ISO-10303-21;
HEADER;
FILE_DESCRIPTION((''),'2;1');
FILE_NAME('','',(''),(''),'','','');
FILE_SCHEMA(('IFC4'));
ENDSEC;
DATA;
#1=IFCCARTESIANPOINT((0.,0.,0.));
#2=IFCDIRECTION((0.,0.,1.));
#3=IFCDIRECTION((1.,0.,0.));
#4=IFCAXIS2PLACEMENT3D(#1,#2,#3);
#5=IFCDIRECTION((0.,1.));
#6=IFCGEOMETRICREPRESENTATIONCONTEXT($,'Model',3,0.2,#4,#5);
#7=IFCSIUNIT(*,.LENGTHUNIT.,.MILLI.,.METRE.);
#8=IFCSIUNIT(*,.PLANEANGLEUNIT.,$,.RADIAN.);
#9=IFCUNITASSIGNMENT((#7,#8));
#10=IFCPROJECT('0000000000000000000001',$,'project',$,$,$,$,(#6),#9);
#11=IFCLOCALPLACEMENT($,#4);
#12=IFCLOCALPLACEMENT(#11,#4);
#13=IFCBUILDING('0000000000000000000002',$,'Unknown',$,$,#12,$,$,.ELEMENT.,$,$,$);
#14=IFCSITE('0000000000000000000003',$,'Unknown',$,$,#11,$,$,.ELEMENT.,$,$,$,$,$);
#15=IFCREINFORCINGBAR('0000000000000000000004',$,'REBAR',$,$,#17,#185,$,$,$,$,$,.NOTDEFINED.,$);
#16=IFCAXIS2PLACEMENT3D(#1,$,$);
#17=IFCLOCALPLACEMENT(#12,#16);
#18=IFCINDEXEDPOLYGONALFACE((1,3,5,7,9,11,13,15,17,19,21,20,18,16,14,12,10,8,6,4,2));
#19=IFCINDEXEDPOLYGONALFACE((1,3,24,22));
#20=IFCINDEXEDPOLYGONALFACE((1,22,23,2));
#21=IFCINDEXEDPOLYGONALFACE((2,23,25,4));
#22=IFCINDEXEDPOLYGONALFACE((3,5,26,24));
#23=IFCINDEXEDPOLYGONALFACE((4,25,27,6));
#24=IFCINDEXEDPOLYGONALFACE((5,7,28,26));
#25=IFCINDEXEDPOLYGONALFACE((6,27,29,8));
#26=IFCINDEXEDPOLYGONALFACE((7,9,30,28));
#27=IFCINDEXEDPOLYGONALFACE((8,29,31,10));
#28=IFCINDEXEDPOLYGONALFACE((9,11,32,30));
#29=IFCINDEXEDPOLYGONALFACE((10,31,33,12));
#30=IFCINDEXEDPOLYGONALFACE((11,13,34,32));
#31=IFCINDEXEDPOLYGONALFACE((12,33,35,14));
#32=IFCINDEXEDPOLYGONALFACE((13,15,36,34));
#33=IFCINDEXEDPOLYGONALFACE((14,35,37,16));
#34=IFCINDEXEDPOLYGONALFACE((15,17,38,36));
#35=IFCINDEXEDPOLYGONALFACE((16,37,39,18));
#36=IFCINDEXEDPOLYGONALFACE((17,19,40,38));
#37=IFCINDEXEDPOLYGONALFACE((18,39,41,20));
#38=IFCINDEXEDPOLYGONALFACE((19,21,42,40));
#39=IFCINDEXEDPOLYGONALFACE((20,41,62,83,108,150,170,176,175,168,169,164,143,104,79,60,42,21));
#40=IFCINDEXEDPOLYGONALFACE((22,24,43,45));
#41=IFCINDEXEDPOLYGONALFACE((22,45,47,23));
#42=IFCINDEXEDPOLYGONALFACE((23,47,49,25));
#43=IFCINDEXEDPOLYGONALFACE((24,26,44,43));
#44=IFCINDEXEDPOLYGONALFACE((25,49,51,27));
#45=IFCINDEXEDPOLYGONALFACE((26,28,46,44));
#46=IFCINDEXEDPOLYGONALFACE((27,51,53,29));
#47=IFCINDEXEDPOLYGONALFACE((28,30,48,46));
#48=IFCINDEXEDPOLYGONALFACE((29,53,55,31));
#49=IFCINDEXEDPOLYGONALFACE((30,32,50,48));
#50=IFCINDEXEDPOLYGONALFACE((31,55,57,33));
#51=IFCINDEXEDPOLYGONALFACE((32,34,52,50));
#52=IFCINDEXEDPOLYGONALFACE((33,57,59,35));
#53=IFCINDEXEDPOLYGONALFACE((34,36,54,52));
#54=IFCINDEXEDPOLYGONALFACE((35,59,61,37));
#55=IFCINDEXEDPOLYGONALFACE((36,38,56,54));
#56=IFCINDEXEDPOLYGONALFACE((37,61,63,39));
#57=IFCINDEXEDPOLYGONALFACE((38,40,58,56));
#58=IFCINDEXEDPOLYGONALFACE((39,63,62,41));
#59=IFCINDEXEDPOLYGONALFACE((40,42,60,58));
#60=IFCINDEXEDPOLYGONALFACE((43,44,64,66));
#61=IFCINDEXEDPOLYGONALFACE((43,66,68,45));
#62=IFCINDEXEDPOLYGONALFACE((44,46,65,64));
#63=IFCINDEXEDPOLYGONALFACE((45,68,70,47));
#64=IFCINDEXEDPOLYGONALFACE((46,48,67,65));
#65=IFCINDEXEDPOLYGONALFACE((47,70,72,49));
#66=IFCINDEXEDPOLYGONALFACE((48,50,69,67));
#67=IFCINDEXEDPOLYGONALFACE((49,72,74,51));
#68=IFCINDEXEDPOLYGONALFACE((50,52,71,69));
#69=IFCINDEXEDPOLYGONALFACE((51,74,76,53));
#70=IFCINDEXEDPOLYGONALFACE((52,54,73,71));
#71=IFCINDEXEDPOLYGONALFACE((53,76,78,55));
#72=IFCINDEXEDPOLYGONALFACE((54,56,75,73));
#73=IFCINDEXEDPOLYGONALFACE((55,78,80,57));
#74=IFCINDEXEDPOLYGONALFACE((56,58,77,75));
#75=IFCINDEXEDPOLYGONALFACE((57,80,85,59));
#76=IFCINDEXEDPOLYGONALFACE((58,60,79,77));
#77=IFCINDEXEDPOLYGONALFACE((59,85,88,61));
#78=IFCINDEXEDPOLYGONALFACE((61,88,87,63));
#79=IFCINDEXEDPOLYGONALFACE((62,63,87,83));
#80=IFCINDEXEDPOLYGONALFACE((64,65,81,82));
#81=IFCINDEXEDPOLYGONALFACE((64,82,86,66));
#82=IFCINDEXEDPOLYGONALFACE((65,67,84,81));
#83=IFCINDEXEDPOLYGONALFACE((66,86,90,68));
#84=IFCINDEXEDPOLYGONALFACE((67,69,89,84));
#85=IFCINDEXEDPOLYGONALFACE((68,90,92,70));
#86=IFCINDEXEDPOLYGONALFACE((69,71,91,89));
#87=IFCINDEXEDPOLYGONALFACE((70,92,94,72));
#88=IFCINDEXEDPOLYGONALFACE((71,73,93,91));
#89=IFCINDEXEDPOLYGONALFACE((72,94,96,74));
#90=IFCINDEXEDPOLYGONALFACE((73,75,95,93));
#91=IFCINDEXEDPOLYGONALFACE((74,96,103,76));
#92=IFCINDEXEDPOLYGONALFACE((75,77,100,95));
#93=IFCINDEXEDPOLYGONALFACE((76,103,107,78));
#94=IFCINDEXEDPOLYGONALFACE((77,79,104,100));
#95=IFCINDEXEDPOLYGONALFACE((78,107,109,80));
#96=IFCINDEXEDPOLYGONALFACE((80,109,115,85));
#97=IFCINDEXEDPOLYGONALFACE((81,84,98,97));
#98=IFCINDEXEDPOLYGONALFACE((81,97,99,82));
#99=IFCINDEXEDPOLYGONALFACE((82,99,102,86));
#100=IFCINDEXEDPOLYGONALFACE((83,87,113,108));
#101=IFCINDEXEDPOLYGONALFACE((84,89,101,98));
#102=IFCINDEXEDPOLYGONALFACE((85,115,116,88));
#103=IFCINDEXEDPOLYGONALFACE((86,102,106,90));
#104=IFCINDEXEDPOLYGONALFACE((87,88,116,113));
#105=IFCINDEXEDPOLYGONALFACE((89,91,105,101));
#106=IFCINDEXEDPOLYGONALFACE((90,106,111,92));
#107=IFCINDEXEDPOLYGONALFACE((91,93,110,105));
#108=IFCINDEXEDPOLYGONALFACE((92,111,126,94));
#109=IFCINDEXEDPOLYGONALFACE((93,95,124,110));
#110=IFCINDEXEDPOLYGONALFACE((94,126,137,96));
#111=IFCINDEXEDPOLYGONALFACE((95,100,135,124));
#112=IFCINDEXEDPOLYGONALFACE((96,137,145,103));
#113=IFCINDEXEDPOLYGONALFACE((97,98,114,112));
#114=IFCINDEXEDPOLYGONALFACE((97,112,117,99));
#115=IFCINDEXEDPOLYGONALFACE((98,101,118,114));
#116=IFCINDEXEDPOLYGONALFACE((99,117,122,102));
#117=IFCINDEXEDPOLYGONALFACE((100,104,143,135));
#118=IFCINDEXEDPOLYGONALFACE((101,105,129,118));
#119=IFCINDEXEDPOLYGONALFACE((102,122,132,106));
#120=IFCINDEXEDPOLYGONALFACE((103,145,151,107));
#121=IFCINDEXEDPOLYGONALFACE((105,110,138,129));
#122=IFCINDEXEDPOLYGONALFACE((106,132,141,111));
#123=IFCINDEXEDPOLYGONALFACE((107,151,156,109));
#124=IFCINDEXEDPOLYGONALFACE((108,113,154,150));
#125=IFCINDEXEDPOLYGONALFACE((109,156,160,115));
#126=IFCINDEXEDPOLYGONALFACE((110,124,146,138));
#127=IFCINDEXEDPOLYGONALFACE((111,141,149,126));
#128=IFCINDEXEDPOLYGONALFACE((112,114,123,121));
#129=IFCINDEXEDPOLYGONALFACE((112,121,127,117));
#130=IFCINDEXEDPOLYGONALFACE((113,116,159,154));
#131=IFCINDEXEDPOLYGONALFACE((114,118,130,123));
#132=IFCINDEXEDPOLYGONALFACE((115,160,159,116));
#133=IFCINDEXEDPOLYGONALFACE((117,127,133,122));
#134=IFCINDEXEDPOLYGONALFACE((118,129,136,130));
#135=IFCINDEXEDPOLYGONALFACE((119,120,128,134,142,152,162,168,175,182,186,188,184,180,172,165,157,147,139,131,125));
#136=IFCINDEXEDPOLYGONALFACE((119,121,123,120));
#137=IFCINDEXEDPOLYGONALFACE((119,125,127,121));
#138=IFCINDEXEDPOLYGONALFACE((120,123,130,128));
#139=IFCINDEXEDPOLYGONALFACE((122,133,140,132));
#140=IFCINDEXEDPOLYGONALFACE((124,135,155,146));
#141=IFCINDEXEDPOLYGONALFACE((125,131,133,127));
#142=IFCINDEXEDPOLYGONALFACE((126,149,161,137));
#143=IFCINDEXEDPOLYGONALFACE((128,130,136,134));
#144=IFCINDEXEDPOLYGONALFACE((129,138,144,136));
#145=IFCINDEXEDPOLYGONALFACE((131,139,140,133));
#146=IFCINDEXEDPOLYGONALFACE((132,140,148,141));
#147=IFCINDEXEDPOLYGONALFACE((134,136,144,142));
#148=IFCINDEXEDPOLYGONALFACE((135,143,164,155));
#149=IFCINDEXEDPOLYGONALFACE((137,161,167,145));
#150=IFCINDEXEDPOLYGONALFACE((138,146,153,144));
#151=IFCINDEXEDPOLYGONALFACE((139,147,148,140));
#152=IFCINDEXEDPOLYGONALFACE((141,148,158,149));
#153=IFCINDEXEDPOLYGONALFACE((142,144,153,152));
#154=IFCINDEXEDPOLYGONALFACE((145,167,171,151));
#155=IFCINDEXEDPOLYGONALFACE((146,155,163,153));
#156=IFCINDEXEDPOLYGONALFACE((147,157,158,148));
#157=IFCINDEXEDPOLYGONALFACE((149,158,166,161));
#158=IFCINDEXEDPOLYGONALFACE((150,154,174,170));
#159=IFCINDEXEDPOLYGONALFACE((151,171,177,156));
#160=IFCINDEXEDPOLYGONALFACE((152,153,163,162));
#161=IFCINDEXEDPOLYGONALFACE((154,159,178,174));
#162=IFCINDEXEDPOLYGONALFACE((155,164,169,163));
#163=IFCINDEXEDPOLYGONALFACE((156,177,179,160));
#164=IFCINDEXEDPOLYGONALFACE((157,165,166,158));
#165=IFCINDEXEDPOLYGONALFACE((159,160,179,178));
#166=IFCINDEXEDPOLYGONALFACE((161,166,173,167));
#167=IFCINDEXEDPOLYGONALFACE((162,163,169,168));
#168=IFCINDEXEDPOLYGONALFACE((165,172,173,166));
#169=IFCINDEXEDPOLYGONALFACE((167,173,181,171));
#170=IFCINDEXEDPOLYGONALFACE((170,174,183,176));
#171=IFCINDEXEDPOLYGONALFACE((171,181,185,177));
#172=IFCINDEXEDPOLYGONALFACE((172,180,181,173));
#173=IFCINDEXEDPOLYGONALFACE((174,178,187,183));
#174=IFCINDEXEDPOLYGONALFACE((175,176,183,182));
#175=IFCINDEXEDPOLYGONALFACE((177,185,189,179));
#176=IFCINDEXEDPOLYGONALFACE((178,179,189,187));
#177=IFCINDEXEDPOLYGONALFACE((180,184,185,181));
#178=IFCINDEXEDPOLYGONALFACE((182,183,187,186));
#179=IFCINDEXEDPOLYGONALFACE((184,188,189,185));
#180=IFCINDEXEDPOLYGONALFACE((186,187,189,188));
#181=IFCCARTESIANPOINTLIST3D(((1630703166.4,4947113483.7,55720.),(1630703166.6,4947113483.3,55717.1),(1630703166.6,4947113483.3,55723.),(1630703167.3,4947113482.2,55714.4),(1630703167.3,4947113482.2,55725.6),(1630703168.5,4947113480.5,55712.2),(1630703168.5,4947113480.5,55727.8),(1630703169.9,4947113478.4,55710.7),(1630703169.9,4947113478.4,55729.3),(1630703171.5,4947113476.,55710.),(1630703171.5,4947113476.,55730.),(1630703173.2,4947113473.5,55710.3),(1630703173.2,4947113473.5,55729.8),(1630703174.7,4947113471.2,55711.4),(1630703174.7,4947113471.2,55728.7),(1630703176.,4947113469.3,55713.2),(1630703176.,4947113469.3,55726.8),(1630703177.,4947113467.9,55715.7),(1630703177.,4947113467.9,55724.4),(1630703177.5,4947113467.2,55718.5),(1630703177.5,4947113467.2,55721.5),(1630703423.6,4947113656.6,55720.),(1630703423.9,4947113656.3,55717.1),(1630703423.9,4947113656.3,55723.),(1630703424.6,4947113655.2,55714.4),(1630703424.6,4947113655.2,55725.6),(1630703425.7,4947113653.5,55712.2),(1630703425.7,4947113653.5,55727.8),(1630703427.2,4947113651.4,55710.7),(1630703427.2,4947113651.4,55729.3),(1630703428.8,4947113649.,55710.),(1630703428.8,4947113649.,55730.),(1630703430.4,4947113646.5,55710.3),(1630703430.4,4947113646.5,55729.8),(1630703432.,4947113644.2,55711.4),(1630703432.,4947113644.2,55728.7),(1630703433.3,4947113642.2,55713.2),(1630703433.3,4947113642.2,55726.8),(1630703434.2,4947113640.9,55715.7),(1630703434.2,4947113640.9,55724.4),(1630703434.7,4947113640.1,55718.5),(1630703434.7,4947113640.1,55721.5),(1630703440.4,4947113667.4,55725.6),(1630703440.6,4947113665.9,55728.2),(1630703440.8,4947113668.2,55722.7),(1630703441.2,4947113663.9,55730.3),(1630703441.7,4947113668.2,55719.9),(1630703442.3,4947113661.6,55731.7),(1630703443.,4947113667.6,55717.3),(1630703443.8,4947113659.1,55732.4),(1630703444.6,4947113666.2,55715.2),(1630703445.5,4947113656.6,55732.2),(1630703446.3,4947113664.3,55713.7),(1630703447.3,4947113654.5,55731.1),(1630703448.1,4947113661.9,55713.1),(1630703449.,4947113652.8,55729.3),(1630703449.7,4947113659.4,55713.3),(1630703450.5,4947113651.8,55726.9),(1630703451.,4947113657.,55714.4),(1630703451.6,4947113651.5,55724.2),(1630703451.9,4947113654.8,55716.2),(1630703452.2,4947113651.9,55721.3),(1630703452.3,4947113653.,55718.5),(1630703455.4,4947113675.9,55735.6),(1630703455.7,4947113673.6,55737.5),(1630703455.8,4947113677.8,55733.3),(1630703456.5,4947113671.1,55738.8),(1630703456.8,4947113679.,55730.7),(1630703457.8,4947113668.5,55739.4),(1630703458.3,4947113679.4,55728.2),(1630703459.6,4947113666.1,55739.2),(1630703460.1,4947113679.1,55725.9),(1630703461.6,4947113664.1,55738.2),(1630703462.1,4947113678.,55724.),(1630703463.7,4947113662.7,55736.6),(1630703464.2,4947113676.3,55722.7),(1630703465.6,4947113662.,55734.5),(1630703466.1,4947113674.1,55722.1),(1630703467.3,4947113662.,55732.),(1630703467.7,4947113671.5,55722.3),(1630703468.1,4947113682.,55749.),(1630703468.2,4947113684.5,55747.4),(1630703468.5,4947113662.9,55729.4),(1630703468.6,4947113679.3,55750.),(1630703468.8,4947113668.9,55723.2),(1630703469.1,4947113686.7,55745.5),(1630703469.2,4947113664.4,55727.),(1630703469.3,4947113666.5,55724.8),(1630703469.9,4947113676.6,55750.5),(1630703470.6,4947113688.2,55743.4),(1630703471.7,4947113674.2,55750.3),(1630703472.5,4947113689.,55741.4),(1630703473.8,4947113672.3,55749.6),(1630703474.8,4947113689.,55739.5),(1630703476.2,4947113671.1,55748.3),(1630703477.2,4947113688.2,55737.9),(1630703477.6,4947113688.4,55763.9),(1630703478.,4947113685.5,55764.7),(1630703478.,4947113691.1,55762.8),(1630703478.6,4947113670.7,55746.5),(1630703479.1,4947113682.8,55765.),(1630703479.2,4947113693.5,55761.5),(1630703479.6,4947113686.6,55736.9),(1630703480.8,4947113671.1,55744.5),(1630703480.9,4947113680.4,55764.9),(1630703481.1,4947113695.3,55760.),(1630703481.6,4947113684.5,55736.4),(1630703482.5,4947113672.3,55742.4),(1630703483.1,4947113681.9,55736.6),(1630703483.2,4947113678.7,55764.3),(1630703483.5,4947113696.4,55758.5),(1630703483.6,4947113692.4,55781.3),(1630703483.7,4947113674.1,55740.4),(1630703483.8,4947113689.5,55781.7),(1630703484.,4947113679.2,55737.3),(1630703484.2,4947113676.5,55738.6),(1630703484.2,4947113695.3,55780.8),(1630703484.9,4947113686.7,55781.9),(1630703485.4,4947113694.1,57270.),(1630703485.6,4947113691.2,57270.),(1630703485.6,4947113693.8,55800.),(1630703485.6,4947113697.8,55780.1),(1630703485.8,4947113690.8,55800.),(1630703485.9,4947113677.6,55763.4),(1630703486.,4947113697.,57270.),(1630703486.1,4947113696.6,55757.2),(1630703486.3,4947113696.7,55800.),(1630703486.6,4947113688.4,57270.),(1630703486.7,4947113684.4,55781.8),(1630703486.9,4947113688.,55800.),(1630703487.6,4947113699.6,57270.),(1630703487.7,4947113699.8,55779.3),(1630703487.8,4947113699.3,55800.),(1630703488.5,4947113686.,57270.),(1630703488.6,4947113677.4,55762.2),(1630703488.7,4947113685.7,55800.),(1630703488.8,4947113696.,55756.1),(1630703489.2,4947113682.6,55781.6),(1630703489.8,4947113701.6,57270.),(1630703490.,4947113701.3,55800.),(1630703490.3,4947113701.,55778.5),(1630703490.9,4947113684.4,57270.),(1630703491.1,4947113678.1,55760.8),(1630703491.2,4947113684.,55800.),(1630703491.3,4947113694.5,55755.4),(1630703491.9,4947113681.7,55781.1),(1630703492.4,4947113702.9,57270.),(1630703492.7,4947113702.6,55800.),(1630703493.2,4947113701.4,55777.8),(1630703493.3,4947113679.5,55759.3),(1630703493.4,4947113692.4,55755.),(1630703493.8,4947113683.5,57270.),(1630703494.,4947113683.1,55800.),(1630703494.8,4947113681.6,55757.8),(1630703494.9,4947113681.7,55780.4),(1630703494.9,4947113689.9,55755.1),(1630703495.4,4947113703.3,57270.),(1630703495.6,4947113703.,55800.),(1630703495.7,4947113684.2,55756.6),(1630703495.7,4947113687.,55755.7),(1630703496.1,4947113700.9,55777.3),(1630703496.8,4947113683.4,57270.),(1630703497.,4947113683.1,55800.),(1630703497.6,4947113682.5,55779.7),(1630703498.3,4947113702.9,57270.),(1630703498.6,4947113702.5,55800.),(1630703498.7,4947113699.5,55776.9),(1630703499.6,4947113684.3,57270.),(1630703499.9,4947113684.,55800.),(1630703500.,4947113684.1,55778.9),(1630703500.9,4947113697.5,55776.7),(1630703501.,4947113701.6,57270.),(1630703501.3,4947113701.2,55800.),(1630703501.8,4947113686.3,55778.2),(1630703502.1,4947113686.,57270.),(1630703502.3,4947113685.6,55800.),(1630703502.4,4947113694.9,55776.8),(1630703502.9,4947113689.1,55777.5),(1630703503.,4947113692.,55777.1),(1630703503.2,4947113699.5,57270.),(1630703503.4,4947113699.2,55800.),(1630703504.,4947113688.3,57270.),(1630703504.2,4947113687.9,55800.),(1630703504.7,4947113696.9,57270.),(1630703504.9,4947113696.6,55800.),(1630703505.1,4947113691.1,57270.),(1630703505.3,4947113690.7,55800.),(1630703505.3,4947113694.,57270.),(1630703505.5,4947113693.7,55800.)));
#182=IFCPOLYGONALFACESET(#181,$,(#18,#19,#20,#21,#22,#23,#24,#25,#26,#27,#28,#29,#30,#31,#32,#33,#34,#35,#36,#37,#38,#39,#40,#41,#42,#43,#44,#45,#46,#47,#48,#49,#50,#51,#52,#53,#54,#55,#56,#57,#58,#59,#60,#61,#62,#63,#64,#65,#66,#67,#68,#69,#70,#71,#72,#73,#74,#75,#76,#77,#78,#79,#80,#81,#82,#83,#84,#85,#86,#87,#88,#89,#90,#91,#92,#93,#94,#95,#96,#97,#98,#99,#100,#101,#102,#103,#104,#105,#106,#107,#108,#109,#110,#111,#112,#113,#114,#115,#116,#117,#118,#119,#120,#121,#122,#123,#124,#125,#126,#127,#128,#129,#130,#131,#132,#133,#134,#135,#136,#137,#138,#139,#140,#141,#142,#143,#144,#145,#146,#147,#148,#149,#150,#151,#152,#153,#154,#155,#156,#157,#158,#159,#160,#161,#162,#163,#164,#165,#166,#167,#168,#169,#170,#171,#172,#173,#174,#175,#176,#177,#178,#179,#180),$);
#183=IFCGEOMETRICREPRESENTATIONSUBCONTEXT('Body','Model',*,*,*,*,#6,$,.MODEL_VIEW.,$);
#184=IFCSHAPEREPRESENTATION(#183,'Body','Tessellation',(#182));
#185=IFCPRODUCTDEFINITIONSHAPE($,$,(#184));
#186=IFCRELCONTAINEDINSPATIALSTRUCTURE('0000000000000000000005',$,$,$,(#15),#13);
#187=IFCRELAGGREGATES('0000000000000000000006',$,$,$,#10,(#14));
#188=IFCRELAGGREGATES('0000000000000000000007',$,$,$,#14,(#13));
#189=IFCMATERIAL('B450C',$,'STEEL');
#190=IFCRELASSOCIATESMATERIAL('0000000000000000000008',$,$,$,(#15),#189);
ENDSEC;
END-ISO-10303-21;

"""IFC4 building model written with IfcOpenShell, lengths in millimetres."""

from ifc_helpers import new_model, entity, si_unit, direction, frame, origin_with_axes, place, context, subcontext, project, spatial, material, element, save


model = new_model("IFC4")

# Units and contexts
model_context = context("Model", 3, precision=0.2, world=origin_with_axes(), true_north=direction((0.0, 1.0)))
body_context = subcontext(model_context, "Body", "Model", "MODEL_VIEW")
ifc_project = project(units=[si_unit("LENGTHUNIT", "METRE", prefix="MILLI"), si_unit("PLANEANGLEUNIT", "RADIAN")], contexts=[model_context])

# Site, building
site_placement = place(None, origin_with_axes())
site = spatial("IfcSite", under=ifc_project, at=site_placement, Name="Unknown", CompositionType="ELEMENT")
building_placement = place(site_placement, origin_with_axes())
building = spatial("IfcBuilding", under=site, at=building_placement, Name="Unknown", CompositionType="ELEMENT")

# Reinforcing bar
ifc_material = material(Name="B450C", Category="STEEL")
reinforcing_bar_1_placement = place(building_placement, frame((1630703509.2, 4947113762.4, 55670.0), z_axis=(0.557991, -0.829847, 0.0), x_axis=(0.0, 0.0, 1.0)))
element("IfcReinforcingBar", 1, at=reinforcing_bar_1_placement, inside=building, material=ifc_material, Name="REBAR", PredefinedType="NOTDEFINED", context=body_context, shape_type="AdvancedSweptSolid", body=[
    entity("IfcSweptDiskSolid", entity("IfcIndexedPolyCurve", entity("IfcCartesianPointList3D", [[50.0, 440.0, 50.0], [50.0, 130.0, 50.0], [73.4, 73.4, 50.0], [130.0, 50.0, 50.0], [1600.0, 50.0, 49.5]]), [entity("IfcLineIndex", [1, 2]), entity("IfcArcIndex", [2, 3, 4]), entity("IfcLineIndex", [4, 5])]), 10.0),
])

save(model, "model.ifc")
